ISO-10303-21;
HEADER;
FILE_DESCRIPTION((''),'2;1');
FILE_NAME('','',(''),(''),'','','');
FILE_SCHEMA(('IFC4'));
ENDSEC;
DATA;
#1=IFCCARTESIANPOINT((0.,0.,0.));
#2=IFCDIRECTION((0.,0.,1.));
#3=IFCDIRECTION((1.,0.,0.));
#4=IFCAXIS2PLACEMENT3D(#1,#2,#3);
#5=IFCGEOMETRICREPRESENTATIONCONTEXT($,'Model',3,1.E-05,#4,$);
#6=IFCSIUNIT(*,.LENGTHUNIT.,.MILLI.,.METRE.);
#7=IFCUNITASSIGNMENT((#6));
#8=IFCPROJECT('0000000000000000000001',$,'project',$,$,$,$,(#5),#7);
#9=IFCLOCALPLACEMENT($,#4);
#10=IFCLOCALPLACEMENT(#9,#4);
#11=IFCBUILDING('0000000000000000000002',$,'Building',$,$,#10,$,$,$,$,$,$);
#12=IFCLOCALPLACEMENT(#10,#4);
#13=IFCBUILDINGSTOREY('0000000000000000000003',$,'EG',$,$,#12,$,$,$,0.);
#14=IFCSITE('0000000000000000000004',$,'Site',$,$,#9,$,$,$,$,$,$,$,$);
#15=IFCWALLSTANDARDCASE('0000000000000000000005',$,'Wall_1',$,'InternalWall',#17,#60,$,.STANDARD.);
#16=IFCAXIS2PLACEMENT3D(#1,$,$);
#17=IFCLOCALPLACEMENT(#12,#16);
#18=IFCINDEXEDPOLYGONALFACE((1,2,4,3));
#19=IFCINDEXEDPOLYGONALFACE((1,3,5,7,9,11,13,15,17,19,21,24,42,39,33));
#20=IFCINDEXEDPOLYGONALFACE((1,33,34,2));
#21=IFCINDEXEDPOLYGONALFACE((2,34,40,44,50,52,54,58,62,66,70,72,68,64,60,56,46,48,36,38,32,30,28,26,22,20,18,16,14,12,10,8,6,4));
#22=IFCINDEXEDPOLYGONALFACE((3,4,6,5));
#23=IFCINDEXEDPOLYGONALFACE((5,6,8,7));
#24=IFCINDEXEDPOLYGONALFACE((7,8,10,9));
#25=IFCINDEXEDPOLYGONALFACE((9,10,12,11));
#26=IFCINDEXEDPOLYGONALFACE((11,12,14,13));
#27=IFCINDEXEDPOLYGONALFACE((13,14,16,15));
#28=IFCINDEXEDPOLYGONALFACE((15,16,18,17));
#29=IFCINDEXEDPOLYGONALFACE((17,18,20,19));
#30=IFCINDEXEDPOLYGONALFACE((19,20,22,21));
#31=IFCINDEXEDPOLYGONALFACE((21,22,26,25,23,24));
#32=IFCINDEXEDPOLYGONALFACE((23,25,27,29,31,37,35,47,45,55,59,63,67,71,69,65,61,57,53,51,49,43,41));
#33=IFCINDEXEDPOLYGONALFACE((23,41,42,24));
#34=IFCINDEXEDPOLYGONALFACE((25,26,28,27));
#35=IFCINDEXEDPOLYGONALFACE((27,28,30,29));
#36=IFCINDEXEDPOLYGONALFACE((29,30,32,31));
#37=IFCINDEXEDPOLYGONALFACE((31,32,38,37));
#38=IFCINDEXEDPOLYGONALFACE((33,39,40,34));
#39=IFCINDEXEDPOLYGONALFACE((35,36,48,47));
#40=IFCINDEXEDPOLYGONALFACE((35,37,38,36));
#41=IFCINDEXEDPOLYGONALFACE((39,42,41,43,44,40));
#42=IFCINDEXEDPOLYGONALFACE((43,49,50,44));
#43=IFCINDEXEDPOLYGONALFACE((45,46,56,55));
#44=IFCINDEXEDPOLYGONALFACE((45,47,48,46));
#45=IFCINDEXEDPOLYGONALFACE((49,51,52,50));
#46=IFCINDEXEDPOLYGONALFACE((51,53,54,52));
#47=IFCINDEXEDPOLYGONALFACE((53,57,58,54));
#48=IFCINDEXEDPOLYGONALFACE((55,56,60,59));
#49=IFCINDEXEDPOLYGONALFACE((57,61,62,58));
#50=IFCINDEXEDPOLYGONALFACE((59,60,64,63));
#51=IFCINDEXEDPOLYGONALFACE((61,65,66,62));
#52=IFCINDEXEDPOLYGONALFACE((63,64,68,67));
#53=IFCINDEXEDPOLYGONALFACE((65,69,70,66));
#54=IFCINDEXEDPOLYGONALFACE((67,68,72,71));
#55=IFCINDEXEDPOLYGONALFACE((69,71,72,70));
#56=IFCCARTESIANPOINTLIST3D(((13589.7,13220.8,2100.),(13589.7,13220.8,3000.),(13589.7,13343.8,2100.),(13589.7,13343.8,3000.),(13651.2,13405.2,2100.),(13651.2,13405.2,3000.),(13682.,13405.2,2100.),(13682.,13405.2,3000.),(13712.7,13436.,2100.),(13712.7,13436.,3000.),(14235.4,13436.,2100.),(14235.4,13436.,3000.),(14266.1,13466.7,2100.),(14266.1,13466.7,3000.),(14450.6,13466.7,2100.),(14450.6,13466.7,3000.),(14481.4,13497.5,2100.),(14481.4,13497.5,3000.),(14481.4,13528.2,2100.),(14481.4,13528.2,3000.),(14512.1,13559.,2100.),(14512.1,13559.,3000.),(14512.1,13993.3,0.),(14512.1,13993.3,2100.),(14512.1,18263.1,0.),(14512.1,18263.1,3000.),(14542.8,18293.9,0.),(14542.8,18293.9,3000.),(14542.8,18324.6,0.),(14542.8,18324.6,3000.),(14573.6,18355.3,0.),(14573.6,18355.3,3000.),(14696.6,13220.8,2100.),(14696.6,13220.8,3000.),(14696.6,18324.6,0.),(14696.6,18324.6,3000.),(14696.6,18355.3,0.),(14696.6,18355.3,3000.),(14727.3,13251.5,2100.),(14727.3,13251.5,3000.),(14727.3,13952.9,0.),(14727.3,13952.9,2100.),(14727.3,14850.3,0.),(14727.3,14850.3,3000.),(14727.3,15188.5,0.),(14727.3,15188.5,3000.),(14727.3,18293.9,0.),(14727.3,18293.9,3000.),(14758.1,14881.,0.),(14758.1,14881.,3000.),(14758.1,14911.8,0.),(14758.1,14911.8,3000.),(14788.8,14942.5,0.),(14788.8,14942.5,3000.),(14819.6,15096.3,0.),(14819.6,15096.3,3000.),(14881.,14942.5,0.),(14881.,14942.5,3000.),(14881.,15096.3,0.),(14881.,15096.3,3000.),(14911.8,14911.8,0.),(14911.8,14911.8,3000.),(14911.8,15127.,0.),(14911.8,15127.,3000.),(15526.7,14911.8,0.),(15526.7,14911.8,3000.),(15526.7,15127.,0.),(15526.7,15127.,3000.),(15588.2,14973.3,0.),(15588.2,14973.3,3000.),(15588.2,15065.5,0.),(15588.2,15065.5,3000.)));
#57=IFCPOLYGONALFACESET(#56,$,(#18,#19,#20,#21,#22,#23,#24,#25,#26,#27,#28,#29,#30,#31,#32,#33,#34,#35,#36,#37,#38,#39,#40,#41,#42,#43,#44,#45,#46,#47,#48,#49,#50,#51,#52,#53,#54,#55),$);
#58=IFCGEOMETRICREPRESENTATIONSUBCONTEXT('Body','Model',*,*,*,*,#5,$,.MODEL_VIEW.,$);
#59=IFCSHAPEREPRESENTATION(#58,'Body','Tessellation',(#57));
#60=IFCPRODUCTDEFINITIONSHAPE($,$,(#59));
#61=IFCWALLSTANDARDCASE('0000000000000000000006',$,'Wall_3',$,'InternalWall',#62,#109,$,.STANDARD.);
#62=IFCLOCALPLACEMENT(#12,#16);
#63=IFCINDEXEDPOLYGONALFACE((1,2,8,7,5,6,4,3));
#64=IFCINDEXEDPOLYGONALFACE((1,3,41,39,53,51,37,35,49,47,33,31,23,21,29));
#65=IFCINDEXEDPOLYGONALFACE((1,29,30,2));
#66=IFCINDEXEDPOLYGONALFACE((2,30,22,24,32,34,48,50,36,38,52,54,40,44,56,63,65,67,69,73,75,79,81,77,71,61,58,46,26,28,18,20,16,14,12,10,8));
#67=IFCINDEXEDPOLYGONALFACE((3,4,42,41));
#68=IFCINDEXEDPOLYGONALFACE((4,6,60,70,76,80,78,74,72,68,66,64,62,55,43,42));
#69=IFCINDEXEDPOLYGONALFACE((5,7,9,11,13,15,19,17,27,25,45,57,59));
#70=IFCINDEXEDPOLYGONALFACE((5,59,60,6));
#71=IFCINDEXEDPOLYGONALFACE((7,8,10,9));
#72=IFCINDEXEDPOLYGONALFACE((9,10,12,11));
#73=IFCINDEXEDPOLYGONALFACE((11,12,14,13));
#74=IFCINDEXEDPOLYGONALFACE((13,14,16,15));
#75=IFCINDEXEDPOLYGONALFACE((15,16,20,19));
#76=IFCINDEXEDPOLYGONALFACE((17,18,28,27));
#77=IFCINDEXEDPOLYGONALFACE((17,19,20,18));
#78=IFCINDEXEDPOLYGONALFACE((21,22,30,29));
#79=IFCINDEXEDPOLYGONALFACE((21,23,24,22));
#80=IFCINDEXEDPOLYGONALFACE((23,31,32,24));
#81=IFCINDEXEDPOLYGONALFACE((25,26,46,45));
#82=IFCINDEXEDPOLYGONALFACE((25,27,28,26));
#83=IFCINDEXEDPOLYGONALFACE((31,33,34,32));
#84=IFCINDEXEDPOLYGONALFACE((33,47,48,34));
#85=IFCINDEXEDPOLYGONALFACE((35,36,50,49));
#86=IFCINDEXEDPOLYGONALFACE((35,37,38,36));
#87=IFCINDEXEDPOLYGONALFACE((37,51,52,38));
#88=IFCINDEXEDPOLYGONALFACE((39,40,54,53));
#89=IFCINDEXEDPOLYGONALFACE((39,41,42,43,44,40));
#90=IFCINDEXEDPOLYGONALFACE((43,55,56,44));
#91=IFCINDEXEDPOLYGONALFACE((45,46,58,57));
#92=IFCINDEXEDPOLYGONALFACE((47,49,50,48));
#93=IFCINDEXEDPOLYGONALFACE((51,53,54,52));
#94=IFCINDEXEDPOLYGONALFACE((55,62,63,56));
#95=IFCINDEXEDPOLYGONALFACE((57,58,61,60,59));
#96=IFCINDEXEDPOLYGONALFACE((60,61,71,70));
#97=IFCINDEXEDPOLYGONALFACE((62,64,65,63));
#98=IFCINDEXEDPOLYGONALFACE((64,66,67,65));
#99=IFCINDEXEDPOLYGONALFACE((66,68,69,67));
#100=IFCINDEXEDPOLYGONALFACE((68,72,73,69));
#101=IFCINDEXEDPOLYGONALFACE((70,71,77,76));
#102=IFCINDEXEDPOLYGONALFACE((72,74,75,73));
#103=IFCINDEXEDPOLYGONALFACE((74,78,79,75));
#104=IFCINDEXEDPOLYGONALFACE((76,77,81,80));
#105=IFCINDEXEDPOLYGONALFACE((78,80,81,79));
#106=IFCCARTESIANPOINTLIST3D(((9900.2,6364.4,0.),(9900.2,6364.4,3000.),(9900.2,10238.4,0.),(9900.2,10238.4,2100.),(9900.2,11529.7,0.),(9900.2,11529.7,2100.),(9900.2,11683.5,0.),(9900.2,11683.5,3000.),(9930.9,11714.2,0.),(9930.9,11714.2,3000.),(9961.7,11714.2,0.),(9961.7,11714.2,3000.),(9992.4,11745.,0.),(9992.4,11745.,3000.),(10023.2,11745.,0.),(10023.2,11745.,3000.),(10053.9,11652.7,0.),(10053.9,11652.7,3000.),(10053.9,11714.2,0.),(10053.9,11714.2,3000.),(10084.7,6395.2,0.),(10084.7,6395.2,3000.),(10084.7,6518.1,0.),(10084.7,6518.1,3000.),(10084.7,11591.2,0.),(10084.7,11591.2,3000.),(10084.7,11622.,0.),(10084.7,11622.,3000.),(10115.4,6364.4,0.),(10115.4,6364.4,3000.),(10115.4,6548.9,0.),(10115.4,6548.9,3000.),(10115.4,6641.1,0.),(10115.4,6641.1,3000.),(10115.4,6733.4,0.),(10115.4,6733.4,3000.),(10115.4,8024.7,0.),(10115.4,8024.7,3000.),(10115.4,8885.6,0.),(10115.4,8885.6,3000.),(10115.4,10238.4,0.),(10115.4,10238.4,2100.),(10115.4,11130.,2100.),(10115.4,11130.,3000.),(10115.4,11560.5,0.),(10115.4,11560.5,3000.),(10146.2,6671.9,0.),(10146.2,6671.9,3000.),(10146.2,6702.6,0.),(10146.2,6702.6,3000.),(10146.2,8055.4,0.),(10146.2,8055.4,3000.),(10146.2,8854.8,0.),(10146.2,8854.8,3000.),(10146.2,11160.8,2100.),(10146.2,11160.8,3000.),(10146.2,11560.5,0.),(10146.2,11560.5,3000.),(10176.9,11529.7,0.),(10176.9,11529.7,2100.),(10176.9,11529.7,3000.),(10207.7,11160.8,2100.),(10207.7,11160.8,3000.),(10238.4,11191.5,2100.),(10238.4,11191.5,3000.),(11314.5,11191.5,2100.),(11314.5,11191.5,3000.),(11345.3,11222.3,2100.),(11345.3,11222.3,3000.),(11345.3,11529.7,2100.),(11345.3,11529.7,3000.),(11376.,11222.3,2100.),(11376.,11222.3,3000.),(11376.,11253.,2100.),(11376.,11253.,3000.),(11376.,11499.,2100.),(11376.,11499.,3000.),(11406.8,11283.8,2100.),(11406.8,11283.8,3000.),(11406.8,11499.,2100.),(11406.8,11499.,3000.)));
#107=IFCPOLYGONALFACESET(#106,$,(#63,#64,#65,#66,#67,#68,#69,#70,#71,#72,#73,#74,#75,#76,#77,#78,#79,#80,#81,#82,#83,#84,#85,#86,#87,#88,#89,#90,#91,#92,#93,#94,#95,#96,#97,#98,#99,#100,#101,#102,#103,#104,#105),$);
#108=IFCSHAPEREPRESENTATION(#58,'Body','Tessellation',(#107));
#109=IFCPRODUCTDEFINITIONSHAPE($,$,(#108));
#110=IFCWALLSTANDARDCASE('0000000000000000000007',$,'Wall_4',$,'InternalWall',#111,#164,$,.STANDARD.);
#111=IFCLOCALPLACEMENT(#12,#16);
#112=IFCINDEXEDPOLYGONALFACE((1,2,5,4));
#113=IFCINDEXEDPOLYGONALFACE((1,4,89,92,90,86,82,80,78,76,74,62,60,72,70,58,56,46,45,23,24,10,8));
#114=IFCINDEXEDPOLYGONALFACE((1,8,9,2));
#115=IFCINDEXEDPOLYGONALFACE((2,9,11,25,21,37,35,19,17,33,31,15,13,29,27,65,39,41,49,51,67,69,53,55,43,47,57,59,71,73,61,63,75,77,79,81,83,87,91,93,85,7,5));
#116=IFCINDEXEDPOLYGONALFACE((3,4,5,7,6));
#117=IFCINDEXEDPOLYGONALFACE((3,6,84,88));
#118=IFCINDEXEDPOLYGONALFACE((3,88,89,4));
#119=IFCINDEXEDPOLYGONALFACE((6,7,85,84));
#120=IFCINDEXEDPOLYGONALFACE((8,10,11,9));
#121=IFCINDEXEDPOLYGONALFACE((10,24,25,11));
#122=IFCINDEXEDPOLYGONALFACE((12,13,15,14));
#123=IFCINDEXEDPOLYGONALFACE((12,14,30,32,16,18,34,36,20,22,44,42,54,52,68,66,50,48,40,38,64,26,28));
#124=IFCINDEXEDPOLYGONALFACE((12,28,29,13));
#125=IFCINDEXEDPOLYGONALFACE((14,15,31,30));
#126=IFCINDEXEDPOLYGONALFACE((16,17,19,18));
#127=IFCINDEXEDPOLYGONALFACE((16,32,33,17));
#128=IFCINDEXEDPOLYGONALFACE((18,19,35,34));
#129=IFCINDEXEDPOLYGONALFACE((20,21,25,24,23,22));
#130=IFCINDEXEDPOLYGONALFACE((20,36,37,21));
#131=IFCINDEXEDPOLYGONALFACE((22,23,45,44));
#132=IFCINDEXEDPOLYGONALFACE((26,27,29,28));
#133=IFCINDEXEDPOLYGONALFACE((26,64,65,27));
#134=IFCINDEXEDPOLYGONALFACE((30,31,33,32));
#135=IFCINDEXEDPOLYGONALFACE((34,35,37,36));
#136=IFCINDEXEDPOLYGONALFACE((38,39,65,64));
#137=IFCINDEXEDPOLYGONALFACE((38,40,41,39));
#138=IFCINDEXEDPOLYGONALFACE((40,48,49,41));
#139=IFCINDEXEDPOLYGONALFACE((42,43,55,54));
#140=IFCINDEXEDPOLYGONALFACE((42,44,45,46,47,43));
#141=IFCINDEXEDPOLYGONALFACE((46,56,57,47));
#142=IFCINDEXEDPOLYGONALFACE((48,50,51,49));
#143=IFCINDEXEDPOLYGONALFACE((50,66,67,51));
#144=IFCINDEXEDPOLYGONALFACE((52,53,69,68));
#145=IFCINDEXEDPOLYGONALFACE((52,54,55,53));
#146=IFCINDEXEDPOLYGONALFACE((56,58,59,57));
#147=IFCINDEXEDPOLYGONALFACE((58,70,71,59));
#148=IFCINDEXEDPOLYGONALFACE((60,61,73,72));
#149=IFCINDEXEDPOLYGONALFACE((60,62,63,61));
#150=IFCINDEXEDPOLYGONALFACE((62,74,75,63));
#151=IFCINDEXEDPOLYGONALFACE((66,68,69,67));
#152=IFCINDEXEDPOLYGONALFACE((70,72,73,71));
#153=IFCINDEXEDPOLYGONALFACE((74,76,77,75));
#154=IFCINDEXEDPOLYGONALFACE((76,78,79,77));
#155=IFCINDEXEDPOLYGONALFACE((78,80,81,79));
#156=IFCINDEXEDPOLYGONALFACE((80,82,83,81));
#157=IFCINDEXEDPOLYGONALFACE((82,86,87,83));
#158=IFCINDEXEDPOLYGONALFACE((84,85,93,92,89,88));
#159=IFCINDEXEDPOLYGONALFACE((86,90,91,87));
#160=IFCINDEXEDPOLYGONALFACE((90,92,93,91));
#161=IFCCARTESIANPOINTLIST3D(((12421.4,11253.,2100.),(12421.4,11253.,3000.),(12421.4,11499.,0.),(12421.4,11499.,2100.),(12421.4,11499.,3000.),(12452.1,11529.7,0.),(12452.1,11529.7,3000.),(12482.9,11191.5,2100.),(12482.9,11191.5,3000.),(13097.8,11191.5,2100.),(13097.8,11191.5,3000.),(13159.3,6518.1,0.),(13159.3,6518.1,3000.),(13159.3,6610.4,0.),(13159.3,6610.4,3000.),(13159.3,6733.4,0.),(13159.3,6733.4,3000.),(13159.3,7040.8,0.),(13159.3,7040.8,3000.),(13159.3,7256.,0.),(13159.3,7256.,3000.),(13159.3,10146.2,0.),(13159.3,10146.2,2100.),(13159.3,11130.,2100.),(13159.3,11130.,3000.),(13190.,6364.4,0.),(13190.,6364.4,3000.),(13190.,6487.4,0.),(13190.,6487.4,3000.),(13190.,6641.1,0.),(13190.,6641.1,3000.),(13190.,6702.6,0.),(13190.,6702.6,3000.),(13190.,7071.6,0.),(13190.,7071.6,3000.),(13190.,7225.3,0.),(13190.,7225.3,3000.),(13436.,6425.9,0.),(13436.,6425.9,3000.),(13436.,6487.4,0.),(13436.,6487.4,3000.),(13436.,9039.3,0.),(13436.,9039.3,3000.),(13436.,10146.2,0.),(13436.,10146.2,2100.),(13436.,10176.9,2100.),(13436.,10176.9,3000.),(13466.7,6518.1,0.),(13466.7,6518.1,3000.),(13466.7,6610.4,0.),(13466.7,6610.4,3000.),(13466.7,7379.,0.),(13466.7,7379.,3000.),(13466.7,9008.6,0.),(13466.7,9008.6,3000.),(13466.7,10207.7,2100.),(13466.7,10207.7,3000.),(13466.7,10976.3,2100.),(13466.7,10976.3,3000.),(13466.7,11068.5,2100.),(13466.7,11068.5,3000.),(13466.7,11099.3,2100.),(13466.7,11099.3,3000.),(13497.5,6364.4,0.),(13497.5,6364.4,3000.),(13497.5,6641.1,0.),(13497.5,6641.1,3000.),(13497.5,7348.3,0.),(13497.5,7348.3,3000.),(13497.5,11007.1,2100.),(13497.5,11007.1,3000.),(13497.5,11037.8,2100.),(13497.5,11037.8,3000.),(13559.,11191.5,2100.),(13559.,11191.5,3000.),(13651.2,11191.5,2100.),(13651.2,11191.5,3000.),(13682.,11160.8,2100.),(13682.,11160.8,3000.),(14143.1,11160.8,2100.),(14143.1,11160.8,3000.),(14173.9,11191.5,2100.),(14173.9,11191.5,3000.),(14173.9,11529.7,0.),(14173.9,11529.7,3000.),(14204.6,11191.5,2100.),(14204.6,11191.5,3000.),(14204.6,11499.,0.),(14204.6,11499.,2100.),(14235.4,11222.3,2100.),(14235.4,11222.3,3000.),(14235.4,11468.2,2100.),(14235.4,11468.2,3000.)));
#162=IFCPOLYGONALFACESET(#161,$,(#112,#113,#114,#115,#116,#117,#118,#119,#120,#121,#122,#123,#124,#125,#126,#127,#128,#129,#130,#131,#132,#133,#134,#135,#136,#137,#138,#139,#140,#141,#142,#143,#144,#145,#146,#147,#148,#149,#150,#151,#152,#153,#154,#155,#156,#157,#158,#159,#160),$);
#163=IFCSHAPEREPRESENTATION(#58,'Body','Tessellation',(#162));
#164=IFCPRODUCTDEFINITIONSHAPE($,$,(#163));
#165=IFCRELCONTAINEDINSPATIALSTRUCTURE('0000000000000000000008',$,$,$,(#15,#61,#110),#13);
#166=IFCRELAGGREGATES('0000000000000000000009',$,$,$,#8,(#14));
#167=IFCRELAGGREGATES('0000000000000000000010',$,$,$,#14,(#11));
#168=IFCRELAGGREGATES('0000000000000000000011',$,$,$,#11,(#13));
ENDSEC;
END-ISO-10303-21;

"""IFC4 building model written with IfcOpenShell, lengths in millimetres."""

from ifc_helpers import new_model, si_unit, frame, origin_with_axes, place, context, subcontext, project, spatial, polyline, rectangle, outline, extrude, element, save


model = new_model("IFC4")

# Units and contexts
model_context = context("Model", 3, precision=1e-05, world=origin_with_axes())
body_context = subcontext(model_context, "Body", "Model", "MODEL_VIEW")
ifc_project = project(units=[si_unit("LENGTHUNIT", "METRE", prefix="MILLI")], contexts=[model_context])

# Site, building, storey
site_placement = place(None, origin_with_axes())
site = spatial("IfcSite", under=ifc_project, at=site_placement, Name="Site")
building_placement = place(site_placement, origin_with_axes())
building = spatial("IfcBuilding", under=site, at=building_placement, Name="Building")
storey_placement = place(building_placement, origin_with_axes())
storey = spatial("IfcBuildingStorey", under=building, at=storey_placement, Name="EG", Elevation=0.0)

# Wall, opening
wall_1_placement = place(storey_placement, origin_with_axes())
wall_1 = element("IfcWallStandardCase", 1, at=wall_1_placement, inside=storey, Name="Wall_1", ObjectType="InternalWall", PredefinedType="STANDARD", context=body_context, shape_type="SweptSolid", body=[
    extrude(outline(polyline([(13589.7, 13220.8, 0.0), (13589.7, 13343.8, 0.0), (13651.2, 13405.2, 0.0), (13682.0, 13405.2, 0.0), (13712.7, 13436.0, 0.0), (14235.4, 13436.0, 0.0), (14266.1, 13466.7, 0.0), (14450.6, 13466.7, 0.0), (14481.4, 13497.5, 0.0), (14481.4, 13528.2, 0.0), (14512.1, 13559.0, 0.0), (14512.1, 18263.1, 0.0), (14542.8, 18293.9, 0.0), (14542.8, 18324.6, 0.0), (14573.6, 18355.3, 0.0), (14696.6, 18355.3, 0.0), (14696.6, 18324.6, 0.0), (14727.3, 18293.9, 0.0), (14727.3, 15188.5, 0.0), (14819.6, 15096.3, 0.0), (14881.0, 15096.3, 0.0), (14911.8, 15127.0, 0.0), (15526.7, 15127.0, 0.0), (15588.2, 15065.5, 0.0), (15588.2, 14973.3, 0.0), (15526.7, 14911.8, 0.0), (14911.8, 14911.8, 0.0), (14881.0, 14942.5, 0.0), (14788.8, 14942.5, 0.0), (14758.1, 14911.8, 0.0), (14758.1, 14881.0, 0.0), (14727.3, 14850.3, 0.0), (14727.3, 13251.5, 0.0), (14696.6, 13220.8, 0.0), (13589.7, 13220.8, 0.0)])), origin_with_axes(), (0.0, 0.0, 1.0), 3000.0),
])
opening_1_placement = place(wall_1_placement, origin_with_axes())
element("IfcOpeningElement", 2, at=opening_1_placement, inside=storey, cuts=wall_1, context=body_context, shape_type="SweptSolid", body=[
    extrude(rectangle(XDim=929.2, YDim=1664.0), frame((14470.8, 13528.3, 0.0), z_axis=(0.0, 0.0, 1.0), x_axis=(-0.184288, -0.982872, 0.0)), (0.0, 0.0, 1.0), 2100.0),
])

# Wall, openings
wall_2_placement = place(storey_placement, origin_with_axes())
wall_2 = element("IfcWallStandardCase", 3, at=wall_2_placement, inside=storey, Name="Wall_3", ObjectType="InternalWall", PredefinedType="STANDARD", context=body_context, shape_type="SweptSolid", body=[
    extrude(outline(polyline([(9900.2, 6364.4, 0.0), (9900.2, 11683.5, 0.0), (9930.9, 11714.2, 0.0), (9961.7, 11714.2, 0.0), (9992.4, 11745.0, 0.0), (10023.2, 11745.0, 0.0), (10053.9, 11714.2, 0.0), (10053.9, 11652.7, 0.0), (10084.7, 11622.0, 0.0), (10084.7, 11591.2, 0.0), (10115.4, 11560.5, 0.0), (10146.2, 11560.5, 0.0), (10176.9, 11529.7, 0.0), (11345.3, 11529.7, 0.0), (11376.0, 11499.0, 0.0), (11406.8, 11499.0, 0.0), (11406.8, 11283.8, 0.0), (11376.0, 11253.0, 0.0), (11376.0, 11222.3, 0.0), (11345.3, 11222.3, 0.0), (11314.5, 11191.5, 0.0), (10238.4, 11191.5, 0.0), (10207.7, 11160.8, 0.0), (10146.2, 11160.8, 0.0), (10115.4, 11130.0, 0.0), (10115.4, 8885.6, 0.0), (10146.2, 8854.8, 0.0), (10146.2, 8055.4, 0.0), (10115.4, 8024.7, 0.0), (10115.4, 6733.4, 0.0), (10146.2, 6702.6, 0.0), (10146.2, 6671.9, 0.0), (10115.4, 6641.1, 0.0), (10115.4, 6548.9, 0.0), (10084.7, 6518.1, 0.0), (10084.7, 6395.2, 0.0), (10115.4, 6364.4, 0.0), (9900.2, 6364.4, 0.0)])), origin_with_axes(), (0.0, 0.0, 1.0), 3000.0),
])
opening_2_placement = place(wall_2_placement, origin_with_axes())
element("IfcOpeningElement", 4, at=opening_2_placement, inside=storey, cuts=wall_2, context=body_context, shape_type="SweptSolid", body=[
    extrude(rectangle(XDim=1291.3, YDim=1506.6), frame((10653.5, 10884.1, 0.0), z_axis=(0.0, 0.0, 1.0), x_axis=(0.0, -1.0, 0.0)), (0.0, 0.0, 1.0), 2100.0),
])
opening_3_placement = place(wall_2_placement, origin_with_axes())
element("IfcOpeningElement", 5, at=opening_3_placement, inside=storey, cuts=wall_2, context=body_context, shape_type="SweptSolid", body=[
    extrude(rectangle(XDim=900.0, YDim=1506.6), frame((9504.5, 12461.3, 0.0), z_axis=(0.0, 0.0, 1.0), x_axis=(0.0, -1.0, 0.0)), (0.0, 0.0, 1.0), 2100.0),
])

# Wall, opening
wall_3_placement = place(storey_placement, origin_with_axes())
wall_3 = element("IfcWallStandardCase", 6, at=wall_3_placement, inside=storey, Name="Wall_4", ObjectType="InternalWall", PredefinedType="STANDARD", context=body_context, shape_type="SweptSolid", body=[
    extrude(outline(polyline([(13190.0, 6364.4, 0.0), (13190.0, 6487.4, 0.0), (13159.3, 6518.1, 0.0), (13159.3, 6610.4, 0.0), (13190.0, 6641.1, 0.0), (13190.0, 6702.6, 0.0), (13159.3, 6733.4, 0.0), (13159.3, 7040.8, 0.0), (13190.0, 7071.6, 0.0), (13190.0, 7225.3, 0.0), (13159.3, 7256.0, 0.0), (13159.3, 11130.0, 0.0), (13097.8, 11191.5, 0.0), (12482.9, 11191.5, 0.0), (12421.4, 11253.0, 0.0), (12421.4, 11499.0, 0.0), (12452.1, 11529.7, 0.0), (14173.9, 11529.7, 0.0), (14235.4, 11468.2, 0.0), (14235.4, 11222.3, 0.0), (14204.6, 11191.5, 0.0), (14173.9, 11191.5, 0.0), (14143.1, 11160.8, 0.0), (13682.0, 11160.8, 0.0), (13651.2, 11191.5, 0.0), (13559.0, 11191.5, 0.0), (13466.7, 11099.3, 0.0), (13466.7, 11068.5, 0.0), (13497.5, 11037.8, 0.0), (13497.5, 11007.1, 0.0), (13466.7, 10976.3, 0.0), (13466.7, 10207.7, 0.0), (13436.0, 10176.9, 0.0), (13436.0, 9039.3, 0.0), (13466.7, 9008.6, 0.0), (13466.7, 7379.0, 0.0), (13497.5, 7348.3, 0.0), (13497.5, 6641.1, 0.0), (13466.7, 6610.4, 0.0), (13466.7, 6518.1, 0.0), (13436.0, 6487.4, 0.0), (13436.0, 6425.9, 0.0), (13497.5, 6364.4, 0.0), (13651.2, 6364.4, 0.0), (13190.0, 6364.4, 0.0)])), origin_with_axes(), (0.0, 0.0, 1.0), 3000.0),
])
opening_4_placement = place(wall_3_placement, origin_with_axes())
element("IfcOpeningElement", 7, at=opening_4_placement, inside=storey, cuts=wall_3, context=body_context, shape_type="SweptSolid", body=[
    extrude(rectangle(XDim=1352.8, YDim=1814.0), frame((13328.4, 10822.6, 0.0), z_axis=(0.0, 0.0, 1.0), x_axis=(0.0, 1.0, 0.0)), (0.0, 0.0, 1.0), 2100.0),
])

save(model, "model.ifc")
